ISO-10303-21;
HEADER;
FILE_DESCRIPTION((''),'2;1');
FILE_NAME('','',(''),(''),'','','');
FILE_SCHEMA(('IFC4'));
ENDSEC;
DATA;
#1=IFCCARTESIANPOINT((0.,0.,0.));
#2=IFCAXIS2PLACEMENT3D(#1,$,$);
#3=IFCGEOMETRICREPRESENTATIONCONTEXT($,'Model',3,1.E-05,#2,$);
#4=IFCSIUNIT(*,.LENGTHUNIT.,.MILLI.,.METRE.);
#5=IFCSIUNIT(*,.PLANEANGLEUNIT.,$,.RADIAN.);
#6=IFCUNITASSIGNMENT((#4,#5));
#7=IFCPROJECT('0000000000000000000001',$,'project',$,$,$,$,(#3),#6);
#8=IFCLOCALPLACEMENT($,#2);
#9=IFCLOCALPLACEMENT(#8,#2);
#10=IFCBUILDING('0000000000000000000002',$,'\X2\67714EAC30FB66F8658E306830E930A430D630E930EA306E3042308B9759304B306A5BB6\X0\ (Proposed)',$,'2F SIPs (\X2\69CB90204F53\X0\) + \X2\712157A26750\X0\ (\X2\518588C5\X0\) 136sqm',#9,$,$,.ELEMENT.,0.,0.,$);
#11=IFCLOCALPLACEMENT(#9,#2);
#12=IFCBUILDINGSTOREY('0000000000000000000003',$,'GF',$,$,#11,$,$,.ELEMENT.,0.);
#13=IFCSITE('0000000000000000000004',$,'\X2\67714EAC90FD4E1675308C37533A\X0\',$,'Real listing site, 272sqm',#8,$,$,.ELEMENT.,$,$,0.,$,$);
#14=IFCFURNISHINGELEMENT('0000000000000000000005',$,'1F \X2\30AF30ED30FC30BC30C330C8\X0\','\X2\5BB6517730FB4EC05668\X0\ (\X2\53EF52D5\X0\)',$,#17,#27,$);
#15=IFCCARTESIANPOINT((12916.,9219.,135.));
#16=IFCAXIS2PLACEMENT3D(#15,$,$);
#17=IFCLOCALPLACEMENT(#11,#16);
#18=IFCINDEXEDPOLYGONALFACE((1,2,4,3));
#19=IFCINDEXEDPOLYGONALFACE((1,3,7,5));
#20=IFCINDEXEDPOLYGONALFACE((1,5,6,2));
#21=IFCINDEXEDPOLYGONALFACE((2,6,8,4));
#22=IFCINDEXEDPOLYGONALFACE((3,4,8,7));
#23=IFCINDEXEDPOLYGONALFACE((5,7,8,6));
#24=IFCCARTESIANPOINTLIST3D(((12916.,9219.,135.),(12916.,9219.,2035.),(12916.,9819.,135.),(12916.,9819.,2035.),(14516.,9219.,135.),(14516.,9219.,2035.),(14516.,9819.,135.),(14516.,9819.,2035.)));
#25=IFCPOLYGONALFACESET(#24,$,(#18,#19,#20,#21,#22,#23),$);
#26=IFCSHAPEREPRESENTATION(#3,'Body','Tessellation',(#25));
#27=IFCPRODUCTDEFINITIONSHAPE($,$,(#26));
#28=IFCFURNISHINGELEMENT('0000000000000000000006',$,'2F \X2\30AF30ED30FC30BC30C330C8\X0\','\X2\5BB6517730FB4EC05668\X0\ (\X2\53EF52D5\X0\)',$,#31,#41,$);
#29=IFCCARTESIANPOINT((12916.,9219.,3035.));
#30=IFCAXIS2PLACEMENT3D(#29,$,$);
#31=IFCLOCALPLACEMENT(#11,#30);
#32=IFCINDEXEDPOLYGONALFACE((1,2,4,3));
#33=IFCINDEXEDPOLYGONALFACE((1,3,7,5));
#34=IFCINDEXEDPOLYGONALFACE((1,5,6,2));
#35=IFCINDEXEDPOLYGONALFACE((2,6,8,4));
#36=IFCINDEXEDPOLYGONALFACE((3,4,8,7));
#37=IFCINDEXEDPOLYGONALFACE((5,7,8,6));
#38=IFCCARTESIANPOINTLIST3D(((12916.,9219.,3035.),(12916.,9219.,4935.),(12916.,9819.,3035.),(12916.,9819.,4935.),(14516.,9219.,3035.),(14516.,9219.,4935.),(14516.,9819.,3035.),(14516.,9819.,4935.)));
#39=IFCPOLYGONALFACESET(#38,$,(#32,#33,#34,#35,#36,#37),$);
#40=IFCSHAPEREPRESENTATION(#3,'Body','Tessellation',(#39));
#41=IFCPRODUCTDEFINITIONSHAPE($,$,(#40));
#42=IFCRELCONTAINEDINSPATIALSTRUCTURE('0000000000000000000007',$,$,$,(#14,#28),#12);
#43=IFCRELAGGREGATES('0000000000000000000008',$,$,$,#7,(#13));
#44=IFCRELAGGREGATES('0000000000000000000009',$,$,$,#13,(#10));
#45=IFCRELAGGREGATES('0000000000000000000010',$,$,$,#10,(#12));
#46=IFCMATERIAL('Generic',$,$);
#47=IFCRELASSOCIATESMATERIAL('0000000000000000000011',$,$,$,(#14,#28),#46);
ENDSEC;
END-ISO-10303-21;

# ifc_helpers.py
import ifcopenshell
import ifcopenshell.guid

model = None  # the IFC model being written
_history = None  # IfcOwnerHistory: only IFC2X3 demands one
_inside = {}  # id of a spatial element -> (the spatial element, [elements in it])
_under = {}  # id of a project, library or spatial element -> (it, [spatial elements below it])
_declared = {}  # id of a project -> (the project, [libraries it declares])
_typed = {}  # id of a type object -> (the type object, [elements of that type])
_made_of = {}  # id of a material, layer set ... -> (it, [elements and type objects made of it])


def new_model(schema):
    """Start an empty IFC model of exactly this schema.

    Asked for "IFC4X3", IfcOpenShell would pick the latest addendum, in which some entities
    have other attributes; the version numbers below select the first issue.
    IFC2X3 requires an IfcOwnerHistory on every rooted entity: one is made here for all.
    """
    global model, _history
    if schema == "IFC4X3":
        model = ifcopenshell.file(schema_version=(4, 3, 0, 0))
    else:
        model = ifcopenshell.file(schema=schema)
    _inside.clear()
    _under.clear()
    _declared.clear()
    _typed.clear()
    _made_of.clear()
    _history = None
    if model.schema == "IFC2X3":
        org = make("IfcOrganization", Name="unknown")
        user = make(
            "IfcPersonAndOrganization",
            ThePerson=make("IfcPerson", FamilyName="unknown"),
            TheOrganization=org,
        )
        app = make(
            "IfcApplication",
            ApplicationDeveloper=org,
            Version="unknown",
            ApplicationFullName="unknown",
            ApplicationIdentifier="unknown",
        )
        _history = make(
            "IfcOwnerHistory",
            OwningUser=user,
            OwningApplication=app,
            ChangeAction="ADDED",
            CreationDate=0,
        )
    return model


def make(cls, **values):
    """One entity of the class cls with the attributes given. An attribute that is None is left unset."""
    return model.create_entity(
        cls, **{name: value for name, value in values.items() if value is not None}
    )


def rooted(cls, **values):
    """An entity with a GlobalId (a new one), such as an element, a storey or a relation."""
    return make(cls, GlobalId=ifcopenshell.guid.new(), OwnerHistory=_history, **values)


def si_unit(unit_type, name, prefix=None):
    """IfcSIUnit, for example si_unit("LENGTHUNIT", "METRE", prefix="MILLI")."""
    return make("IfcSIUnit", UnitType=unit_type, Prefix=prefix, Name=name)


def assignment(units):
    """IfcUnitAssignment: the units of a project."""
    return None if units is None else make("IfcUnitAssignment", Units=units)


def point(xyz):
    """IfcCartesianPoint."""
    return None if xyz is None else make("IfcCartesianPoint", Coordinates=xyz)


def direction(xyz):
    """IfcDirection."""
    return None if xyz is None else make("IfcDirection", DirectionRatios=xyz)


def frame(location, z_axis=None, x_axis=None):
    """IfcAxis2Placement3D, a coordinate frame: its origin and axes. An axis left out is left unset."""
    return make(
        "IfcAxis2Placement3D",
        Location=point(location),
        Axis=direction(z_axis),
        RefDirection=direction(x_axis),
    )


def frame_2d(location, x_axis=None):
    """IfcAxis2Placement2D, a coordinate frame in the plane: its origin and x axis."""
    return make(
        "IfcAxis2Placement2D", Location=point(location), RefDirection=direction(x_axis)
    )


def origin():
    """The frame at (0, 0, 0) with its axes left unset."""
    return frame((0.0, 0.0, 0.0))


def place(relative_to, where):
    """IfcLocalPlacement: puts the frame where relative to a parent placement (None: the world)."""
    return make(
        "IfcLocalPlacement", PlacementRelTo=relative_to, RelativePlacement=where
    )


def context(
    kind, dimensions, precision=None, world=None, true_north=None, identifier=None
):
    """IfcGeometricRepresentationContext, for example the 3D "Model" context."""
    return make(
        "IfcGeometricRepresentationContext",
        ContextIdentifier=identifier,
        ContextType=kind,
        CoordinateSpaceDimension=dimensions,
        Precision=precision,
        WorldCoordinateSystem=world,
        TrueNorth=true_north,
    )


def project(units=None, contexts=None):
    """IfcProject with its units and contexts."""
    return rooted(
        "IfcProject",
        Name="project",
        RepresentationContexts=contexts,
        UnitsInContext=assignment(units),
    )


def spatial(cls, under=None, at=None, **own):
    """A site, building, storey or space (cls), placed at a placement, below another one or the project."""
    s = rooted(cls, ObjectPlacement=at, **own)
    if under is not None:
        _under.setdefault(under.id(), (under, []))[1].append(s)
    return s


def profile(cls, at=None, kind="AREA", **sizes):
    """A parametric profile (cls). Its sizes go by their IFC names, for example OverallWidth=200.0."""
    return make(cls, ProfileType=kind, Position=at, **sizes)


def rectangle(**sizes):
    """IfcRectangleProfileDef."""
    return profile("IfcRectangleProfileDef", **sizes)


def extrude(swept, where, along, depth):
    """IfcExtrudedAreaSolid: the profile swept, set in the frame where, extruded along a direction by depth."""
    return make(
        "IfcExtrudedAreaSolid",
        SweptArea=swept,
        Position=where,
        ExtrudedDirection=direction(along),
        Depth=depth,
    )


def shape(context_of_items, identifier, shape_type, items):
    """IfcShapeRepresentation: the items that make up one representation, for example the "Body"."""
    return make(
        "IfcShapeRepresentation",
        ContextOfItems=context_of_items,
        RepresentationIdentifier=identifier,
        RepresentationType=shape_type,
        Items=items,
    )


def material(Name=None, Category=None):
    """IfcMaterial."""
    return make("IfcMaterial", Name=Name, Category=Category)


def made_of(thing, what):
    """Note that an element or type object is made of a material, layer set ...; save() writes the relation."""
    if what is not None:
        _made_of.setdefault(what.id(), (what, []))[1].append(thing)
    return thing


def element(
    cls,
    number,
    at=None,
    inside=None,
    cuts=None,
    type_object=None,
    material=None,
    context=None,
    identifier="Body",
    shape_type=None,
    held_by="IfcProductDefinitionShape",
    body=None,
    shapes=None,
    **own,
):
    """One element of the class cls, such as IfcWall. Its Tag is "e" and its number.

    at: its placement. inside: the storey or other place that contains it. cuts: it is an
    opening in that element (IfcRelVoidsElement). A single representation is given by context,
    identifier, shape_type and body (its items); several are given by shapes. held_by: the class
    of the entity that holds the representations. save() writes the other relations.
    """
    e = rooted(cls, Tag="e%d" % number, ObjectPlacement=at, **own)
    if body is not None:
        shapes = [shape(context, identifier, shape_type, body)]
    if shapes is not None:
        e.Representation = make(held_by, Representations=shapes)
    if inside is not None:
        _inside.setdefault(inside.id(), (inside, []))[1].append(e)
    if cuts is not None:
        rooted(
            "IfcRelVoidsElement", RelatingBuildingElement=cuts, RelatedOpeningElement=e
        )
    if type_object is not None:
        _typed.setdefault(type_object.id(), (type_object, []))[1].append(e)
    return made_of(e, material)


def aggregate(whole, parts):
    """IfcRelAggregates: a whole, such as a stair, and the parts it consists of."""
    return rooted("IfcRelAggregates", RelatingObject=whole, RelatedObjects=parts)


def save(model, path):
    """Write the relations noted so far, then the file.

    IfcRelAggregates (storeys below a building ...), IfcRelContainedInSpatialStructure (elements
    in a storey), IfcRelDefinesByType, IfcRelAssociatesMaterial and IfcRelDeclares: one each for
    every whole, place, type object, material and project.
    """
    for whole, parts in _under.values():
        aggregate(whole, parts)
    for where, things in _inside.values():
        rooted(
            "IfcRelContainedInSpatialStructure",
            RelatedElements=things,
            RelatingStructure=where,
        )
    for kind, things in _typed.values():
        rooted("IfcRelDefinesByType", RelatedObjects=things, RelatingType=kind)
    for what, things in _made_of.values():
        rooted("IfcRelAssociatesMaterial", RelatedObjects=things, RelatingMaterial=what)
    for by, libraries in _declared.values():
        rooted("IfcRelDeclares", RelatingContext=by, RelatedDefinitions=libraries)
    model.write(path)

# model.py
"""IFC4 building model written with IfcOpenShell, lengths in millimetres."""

from ifc_helpers import new_model, si_unit, frame, frame_2d, origin, place, context, project, spatial, rectangle, extrude, material, element, save


model = new_model("IFC4")

# Units and contexts
model_context = context("Model", 3, precision=1e-05, world=origin())
ifc_project = project(units=[si_unit("LENGTHUNIT", "METRE", prefix="MILLI"), si_unit("PLANEANGLEUNIT", "RADIAN")], contexts=[model_context])

# Site, building, storey
site_placement = place(None, origin())
site = spatial("IfcSite", under=ifc_project, at=site_placement, Name="東京都世田谷区", ObjectType="Real listing site, 272sqm", CompositionType="ELEMENT", RefElevation=0.0)
building_placement = place(site_placement, origin())
building = spatial("IfcBuilding", under=site, at=building_placement, Name="東京・書斎とライブラリのある静かな家 (Proposed)", ObjectType="2F SIPs (構造体) + 無垢材 (内装) 136sqm", CompositionType="ELEMENT", ElevationOfRefHeight=0.0, ElevationOfTerrain=0.0)
storey_placement = place(building_placement, origin())
storey = spatial("IfcBuildingStorey", under=building, at=storey_placement, Name="GF", CompositionType="ELEMENT", Elevation=0.0)

# Shared definitions
ifc_material_1 = material(Name="Generic")

# Furnishing elements
furnishing_1_placement = place(storey_placement, frame((12916.0, 9219.0, 135.0)))
element("IfcFurnishingElement", 1, at=furnishing_1_placement, inside=storey, material=ifc_material_1, Name="1F クローゼット", Description="家具・什器 (可動)", context=model_context, shape_type="SweptSolid", body=[
    extrude(rectangle(XDim=1600.0, YDim=600.0, at=frame_2d((800.0, 300.0))), frame((12916.0, 9219.0, 135.0)), (0.0, 0.0, 1.0), 1900.0),
])
furnishing_2_placement = place(storey_placement, frame((12916.0, 9219.0, 3035.0)))
element("IfcFurnishingElement", 2, at=furnishing_2_placement, inside=storey, material=ifc_material_1, Name="2F クローゼット", Description="家具・什器 (可動)", context=model_context, shape_type="SweptSolid", body=[
    extrude(rectangle(XDim=1600.0, YDim=600.0, at=frame_2d((800.0, 300.0))), frame((12916.0, 9219.0, 3035.0)), (0.0, 0.0, 1.0), 1900.0),
])

save(model, "model.ifc")
